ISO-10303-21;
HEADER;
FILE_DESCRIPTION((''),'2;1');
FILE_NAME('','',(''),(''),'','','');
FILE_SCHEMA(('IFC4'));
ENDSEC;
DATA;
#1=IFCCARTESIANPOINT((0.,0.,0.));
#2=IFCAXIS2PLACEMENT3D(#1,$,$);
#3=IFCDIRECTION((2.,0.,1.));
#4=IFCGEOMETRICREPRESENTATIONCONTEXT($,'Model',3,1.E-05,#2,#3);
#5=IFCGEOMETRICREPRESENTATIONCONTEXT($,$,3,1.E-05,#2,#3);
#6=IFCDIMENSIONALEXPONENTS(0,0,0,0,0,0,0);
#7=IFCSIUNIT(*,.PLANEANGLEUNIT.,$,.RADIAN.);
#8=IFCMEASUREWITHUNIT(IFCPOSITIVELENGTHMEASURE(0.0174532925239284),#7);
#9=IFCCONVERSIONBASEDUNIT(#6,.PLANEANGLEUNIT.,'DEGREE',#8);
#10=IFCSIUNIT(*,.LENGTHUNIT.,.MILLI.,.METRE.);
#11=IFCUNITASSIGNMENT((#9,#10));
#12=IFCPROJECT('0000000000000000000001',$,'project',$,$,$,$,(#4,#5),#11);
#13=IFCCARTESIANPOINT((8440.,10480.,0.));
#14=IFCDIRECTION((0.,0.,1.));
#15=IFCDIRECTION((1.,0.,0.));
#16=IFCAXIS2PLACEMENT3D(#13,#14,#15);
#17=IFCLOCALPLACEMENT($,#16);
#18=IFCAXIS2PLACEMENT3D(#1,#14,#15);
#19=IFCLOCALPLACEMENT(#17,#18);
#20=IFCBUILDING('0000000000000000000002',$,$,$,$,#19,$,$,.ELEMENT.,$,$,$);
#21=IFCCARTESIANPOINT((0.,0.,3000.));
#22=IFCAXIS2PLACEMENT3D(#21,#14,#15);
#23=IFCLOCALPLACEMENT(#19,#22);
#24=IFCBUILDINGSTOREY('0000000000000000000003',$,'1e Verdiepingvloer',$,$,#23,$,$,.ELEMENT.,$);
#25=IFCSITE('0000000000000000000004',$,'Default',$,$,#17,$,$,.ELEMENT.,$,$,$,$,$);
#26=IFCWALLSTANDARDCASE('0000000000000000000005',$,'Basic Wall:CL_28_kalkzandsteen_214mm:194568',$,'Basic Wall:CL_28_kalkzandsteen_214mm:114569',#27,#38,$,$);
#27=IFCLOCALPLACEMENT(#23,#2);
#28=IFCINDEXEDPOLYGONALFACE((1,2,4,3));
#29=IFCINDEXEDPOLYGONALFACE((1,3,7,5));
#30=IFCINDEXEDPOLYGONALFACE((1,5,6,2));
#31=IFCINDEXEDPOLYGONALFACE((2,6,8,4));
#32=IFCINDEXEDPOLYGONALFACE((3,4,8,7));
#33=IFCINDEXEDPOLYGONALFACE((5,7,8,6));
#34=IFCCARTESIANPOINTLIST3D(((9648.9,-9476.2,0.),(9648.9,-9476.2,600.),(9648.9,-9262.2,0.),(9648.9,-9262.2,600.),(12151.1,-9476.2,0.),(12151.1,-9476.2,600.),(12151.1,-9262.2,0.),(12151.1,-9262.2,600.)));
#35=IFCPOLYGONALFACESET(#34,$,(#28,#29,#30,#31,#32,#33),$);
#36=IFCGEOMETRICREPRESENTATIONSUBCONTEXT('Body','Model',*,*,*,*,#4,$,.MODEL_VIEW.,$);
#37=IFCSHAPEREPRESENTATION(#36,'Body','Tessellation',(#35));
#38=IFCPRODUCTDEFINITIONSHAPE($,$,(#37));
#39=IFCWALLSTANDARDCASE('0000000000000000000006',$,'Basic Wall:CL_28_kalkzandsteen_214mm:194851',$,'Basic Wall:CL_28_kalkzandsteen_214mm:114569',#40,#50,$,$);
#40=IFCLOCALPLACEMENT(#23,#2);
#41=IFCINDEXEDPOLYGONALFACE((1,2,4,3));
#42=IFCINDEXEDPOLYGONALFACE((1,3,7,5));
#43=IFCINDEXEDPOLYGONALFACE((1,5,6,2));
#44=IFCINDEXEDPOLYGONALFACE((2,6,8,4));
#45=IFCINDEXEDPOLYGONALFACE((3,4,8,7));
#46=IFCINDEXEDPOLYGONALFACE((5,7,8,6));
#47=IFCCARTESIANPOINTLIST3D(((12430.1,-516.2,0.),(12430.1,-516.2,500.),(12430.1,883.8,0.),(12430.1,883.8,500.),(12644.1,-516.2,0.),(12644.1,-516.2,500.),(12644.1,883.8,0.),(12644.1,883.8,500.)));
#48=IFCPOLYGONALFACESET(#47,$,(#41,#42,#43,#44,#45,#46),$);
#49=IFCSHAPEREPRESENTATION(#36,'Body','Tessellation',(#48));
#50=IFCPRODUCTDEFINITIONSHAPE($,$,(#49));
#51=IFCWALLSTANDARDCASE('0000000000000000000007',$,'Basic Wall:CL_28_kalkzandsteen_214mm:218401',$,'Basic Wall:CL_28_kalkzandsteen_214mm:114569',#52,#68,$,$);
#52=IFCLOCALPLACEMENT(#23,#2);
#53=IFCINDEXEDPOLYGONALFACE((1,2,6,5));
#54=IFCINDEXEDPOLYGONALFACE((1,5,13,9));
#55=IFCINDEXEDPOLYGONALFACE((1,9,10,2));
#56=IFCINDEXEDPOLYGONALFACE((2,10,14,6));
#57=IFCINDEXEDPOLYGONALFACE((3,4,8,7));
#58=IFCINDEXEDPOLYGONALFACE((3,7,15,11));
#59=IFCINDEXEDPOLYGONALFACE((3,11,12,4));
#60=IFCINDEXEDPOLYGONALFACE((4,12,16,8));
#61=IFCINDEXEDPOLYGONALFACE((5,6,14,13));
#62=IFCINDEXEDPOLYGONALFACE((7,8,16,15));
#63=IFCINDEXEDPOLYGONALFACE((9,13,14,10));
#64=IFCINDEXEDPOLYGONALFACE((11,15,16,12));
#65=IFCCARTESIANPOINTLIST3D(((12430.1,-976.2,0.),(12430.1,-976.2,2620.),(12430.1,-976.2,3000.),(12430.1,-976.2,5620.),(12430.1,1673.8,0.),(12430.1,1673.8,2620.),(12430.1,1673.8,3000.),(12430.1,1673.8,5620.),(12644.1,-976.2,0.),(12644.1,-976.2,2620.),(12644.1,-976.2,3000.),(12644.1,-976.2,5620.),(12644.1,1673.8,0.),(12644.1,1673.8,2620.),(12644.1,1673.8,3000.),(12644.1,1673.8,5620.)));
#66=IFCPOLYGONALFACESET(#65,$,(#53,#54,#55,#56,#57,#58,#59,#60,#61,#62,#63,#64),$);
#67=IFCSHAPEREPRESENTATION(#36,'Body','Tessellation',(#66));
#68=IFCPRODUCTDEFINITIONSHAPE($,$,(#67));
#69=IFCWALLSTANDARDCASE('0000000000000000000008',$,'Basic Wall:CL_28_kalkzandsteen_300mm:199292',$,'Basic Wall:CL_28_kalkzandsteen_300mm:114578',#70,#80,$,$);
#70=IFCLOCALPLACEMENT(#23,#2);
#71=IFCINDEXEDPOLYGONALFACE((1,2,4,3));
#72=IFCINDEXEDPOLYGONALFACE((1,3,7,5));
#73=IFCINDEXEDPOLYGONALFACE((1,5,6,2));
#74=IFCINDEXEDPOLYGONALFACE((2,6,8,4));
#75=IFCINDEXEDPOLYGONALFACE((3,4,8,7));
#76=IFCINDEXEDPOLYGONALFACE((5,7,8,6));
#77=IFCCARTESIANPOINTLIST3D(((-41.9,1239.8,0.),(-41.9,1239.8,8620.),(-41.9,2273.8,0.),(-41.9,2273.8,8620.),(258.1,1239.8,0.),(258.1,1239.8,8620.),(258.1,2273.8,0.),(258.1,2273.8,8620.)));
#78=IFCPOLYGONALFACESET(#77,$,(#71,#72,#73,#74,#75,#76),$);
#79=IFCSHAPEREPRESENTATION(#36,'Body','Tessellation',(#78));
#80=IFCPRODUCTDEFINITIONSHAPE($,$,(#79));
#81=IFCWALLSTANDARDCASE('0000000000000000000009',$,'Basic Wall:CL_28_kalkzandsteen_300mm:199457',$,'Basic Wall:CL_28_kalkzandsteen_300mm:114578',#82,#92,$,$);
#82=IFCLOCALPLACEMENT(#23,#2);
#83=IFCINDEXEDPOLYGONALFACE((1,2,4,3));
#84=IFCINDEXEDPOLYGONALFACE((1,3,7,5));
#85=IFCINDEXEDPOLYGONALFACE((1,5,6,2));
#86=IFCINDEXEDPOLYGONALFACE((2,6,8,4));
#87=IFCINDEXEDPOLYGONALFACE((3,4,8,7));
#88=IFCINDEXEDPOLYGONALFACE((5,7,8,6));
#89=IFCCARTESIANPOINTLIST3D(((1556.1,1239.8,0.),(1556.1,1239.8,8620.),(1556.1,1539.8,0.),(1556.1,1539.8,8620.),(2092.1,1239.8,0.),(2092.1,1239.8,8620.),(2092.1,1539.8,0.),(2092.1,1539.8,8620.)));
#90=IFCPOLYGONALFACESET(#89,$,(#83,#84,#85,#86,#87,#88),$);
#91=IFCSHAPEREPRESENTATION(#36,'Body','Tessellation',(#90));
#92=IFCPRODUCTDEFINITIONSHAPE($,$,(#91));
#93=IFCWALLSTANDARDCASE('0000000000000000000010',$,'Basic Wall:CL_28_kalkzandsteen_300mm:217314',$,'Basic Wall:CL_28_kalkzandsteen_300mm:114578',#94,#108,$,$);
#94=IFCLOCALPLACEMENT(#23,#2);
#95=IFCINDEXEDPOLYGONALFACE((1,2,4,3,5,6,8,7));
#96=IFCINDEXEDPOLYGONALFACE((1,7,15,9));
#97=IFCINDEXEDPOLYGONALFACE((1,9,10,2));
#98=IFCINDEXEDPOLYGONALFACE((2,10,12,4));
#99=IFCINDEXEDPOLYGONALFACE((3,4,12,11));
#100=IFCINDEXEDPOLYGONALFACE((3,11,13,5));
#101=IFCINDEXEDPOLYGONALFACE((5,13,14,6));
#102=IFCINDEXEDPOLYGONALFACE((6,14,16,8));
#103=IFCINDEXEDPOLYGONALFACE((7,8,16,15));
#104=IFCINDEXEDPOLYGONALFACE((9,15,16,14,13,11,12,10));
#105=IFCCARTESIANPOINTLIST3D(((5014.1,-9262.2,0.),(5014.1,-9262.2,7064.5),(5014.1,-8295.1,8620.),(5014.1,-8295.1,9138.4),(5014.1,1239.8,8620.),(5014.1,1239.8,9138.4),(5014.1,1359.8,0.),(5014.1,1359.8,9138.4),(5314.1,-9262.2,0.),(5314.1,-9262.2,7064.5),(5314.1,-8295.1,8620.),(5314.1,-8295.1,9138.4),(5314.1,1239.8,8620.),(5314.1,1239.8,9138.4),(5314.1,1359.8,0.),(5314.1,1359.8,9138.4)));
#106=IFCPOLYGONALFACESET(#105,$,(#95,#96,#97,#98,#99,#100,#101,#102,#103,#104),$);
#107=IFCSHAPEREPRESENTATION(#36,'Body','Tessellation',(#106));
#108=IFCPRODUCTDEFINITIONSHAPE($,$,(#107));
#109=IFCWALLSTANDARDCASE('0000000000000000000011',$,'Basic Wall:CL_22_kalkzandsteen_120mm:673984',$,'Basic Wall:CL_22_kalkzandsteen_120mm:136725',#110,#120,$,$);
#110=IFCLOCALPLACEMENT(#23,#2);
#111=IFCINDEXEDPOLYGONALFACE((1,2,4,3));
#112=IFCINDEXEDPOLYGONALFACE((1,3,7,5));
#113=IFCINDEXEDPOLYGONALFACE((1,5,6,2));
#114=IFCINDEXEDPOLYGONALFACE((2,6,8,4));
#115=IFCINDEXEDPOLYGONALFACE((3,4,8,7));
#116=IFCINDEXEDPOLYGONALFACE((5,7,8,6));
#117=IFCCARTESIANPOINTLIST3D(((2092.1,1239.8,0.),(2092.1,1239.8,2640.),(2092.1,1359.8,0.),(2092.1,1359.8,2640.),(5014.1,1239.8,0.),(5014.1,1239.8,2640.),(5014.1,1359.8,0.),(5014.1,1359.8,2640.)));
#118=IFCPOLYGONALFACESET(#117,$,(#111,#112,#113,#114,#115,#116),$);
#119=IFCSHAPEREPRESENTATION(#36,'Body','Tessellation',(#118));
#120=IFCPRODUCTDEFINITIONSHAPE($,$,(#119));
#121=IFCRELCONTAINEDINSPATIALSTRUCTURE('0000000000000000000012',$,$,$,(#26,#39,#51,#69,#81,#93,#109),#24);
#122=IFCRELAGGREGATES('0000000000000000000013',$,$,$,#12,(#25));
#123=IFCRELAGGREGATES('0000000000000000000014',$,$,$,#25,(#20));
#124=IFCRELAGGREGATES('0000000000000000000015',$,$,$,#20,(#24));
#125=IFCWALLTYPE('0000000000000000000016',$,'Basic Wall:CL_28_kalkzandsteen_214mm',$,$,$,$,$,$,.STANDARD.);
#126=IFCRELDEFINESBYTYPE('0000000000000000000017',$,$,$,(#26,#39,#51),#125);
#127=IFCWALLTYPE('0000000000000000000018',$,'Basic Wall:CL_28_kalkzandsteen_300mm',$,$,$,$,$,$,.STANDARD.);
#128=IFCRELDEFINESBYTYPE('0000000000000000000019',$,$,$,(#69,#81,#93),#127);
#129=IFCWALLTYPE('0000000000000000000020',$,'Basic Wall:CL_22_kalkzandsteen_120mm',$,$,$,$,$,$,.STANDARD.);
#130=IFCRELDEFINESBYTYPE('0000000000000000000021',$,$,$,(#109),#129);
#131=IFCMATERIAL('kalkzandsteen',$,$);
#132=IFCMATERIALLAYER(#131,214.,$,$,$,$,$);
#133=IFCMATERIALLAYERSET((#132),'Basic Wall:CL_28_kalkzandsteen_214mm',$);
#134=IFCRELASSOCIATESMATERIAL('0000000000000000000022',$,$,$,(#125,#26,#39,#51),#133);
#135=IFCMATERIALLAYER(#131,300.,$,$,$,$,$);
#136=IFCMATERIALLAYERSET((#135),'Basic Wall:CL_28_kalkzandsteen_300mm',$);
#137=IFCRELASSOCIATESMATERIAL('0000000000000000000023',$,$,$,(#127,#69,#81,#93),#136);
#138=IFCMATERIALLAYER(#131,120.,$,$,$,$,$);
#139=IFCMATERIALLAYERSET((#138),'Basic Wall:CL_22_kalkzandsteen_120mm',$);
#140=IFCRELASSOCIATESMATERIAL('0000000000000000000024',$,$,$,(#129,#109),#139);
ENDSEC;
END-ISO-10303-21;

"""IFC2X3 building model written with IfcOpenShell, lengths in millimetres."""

from ifc_helpers import new_model, entity, si_unit, converted_unit, direction, frame, frame_2d, origin, origin_with_axes, place, context, subcontext, project, spatial, polyline, rectangle, extrude, clip, bounded_halfspace, material, layer, layer_set, layer_usage, type_object, element, save


model = new_model("IFC2X3")

# Units and contexts
model_context = context("Model", 3, precision=1e-05, world=origin(), true_north=direction((2.0, 0.0, 1.0)))
context_of_model = context(None, 3, precision=1e-05, world=origin(), true_north=direction((2.0, 0.0, 1.0)))
body_context = subcontext(model_context, "Body", "Model", "MODEL_VIEW")
ifc_project = project(units=[converted_unit("PLANEANGLEUNIT", "DEGREE", entity("IfcPositiveLengthMeasure", 0.0174532925239284), si_unit("PLANEANGLEUNIT", "RADIAN"), dimensions=[0, 0, 0, 0, 0, 0, 0]), si_unit("LENGTHUNIT", "METRE", prefix="MILLI")], contexts=[model_context, context_of_model])

# Site, building, storey
site_placement = place(None, frame((8440.0, 10480.0, 0.0), z_axis=(0.0, 0.0, 1.0), x_axis=(1.0, 0.0, 0.0)))
site = spatial("IfcSite", under=ifc_project, at=site_placement, Name="Default", CompositionType="ELEMENT")
building_placement = place(site_placement, origin_with_axes())
building = spatial("IfcBuilding", under=site, at=building_placement, CompositionType="ELEMENT")
storey_placement = place(building_placement, frame((0.0, 0.0, 3000.0), z_axis=(0.0, 0.0, 1.0), x_axis=(1.0, 0.0, 0.0)))
storey = spatial("IfcBuildingStorey", under=building, at=storey_placement, Name="1e Verdiepingvloer", CompositionType="ELEMENT")

# Walls
ifc_material_1 = material(Name="kalkzandsteen")
ifc_layer_1 = layer(ifc_material_1, 214.0)
ifc_layer_set_1 = layer_set([ifc_layer_1], Name="Basic Wall:CL_28_kalkzandsteen_214mm")
wall_type_1 = type_object("IfcWallType", Name="Basic Wall:CL_28_kalkzandsteen_214mm", PredefinedType="STANDARD", material=ifc_layer_set_1)
ifc_layer_usage_1 = layer_usage(ifc_layer_set_1, "AXIS2", "NEGATIVE", 107.0)
wall_1_placement = place(storey_placement, frame((9648.9, -9369.2, 0.0), z_axis=(0.0, 0.0, 1.0), x_axis=(1.0, 0.0, 0.0)))
element("IfcWallStandardCase", 1, at=wall_1_placement, inside=storey, type_object=wall_type_1, material=ifc_layer_usage_1, Name="Basic Wall:CL_28_kalkzandsteen_214mm:194568", ObjectType="Basic Wall:CL_28_kalkzandsteen_214mm:114569", context=body_context, shape_type="SweptSolid", body=[
    extrude(rectangle(XDim=2502.2, YDim=214.0, at=frame_2d((1251.1, 0.0), x_axis=(-1.0, 0.0))), origin(), (0.0, 0.0, 1.0), 600.0),
])
ifc_layer_usage_2 = layer_usage(ifc_layer_set_1, "AXIS2", "NEGATIVE", 107.0)
wall_2_placement = place(storey_placement, frame((12537.1, -516.2, 0.0), z_axis=(0.0, 0.0, 1.0), x_axis=(0.0, 1.0, 0.0)))
element("IfcWallStandardCase", 2, at=wall_2_placement, inside=storey, type_object=wall_type_1, material=ifc_layer_usage_2, Name="Basic Wall:CL_28_kalkzandsteen_214mm:194851", ObjectType="Basic Wall:CL_28_kalkzandsteen_214mm:114569", context=body_context, shape_type="SweptSolid", body=[
    extrude(rectangle(XDim=1400.0, YDim=214.0, at=frame_2d((700.0, 0.0), x_axis=(-1.0, 0.0))), origin(), (0.0, 0.0, 1.0), 500.0),
])

# Wall, opening
ifc_layer_usage_3 = layer_usage(ifc_layer_set_1, "AXIS2", "NEGATIVE", 107.0)
wall_3_placement = place(storey_placement, frame((12537.1, -976.2, 0.0), z_axis=(0.0, 0.0, 1.0), x_axis=(0.0, 1.0, 0.0)))
wall_3 = element("IfcWallStandardCase", 3, at=wall_3_placement, inside=storey, type_object=wall_type_1, material=ifc_layer_usage_3, Name="Basic Wall:CL_28_kalkzandsteen_214mm:218401", ObjectType="Basic Wall:CL_28_kalkzandsteen_214mm:114569", context=body_context, shape_type="Clipping", body=[
    clip(extrude(rectangle(XDim=2650.0, YDim=214.0, at=frame_2d((1325.0, 0.0), x_axis=(-1.0, 0.0))), origin(), (0.0, 0.0, 1.0), 5620.0), bounded_halfspace(frame((0.0, -107.0, 5620.0), z_axis=(0.0, 0.0, -1.0), x_axis=(0.0, -1.0, 0.0)), True, frame((0.0, -107.0, 5620.0)), polyline([(0.0, 0.0), (2650.0, 0.0), (2650.0, 214.0), (0.0, 214.0), (0.0, 0.0)]))),
])
opening_placement = place(wall_3_placement, origin_with_axes())
element("IfcOpeningElement", 4, at=opening_placement, cuts=wall_3, ObjectType="Opening", context=body_context, shape_type="SweptSolid", body=[
    extrude(rectangle(XDim=2650.0, YDim=214.0, at=frame_2d((0.0, 0.0), x_axis=(1.0, 0.0))), frame((1325.0, 0.0, 2620.0)), (0.0, 0.0, 1.0), 380.0),
])

# Walls
ifc_layer_2 = layer(ifc_material_1, 300.0)
ifc_layer_set_2 = layer_set([ifc_layer_2], Name="Basic Wall:CL_28_kalkzandsteen_300mm")
ifc_layer_usage_4 = layer_usage(ifc_layer_set_2, "AXIS2", "NEGATIVE", 150.0)
wall_type_2 = type_object("IfcWallType", Name="Basic Wall:CL_28_kalkzandsteen_300mm", PredefinedType="STANDARD", material=ifc_layer_set_2)
wall_4_placement = place(storey_placement, frame((108.1, 1239.8, 0.0), z_axis=(0.0, 0.0, 1.0), x_axis=(0.0, 1.0, 0.0)))
element("IfcWallStandardCase", 5, at=wall_4_placement, inside=storey, type_object=wall_type_2, material=ifc_layer_usage_4, Name="Basic Wall:CL_28_kalkzandsteen_300mm:199292", ObjectType="Basic Wall:CL_28_kalkzandsteen_300mm:114578", context=body_context, shape_type="Clipping", body=[
    clip(extrude(rectangle(XDim=1034.0, YDim=300.0, at=frame_2d((517.0, 0.0), x_axis=(-1.0, 0.0))), origin(), (0.0, 0.0, 1.0), 8620.0), bounded_halfspace(frame((0.0, -150.0, 8620.0), z_axis=(0.0, 0.0, -1.0), x_axis=(-1.0, 0.0, 0.0)), True, frame((0.0, -150.0, 8620.0)), polyline([(0.0, 0.0), (1034.0, 0.0), (1034.0, 300.0), (734.0, 300.0), (0.0, 300.0), (0.0, 0.0)]))),
])
ifc_layer_usage_5 = layer_usage(ifc_layer_set_2, "AXIS2", "NEGATIVE", 150.0)
wall_5_placement = place(storey_placement, frame((1556.1, 1389.8, 0.0), z_axis=(0.0, 0.0, 1.0), x_axis=(1.0, 0.0, 0.0)))
element("IfcWallStandardCase", 6, at=wall_5_placement, inside=storey, type_object=wall_type_2, material=ifc_layer_usage_5, Name="Basic Wall:CL_28_kalkzandsteen_300mm:199457", ObjectType="Basic Wall:CL_28_kalkzandsteen_300mm:114578", context=body_context, shape_type="Clipping", body=[
    clip(extrude(rectangle(XDim=536.0, YDim=300.0, at=frame_2d((268.0, 0.0), x_axis=(-1.0, 0.0))), origin(), (0.0, 0.0, 1.0), 8620.0), bounded_halfspace(frame((0.0, -150.0, 8620.0), z_axis=(0.0, 0.0, -1.0), x_axis=(0.0, -1.0, 0.0)), True, frame((0.0, -150.0, 8620.0)), polyline([(0.0, 0.0), (536.0, 0.0), (536.0, 120.0), (536.0, 300.0), (0.0, 300.0), (0.0, 0.0)]))),
])
ifc_layer_usage_6 = layer_usage(ifc_layer_set_2, "AXIS2", "NEGATIVE", 150.0)
wall_6_placement = place(storey_placement, frame((5164.1, -9262.2, 0.0), z_axis=(0.0, 0.0, 1.0), x_axis=(0.0, 1.0, 0.0)))
element("IfcWallStandardCase", 7, at=wall_6_placement, inside=storey, type_object=wall_type_2, material=ifc_layer_usage_6, Name="Basic Wall:CL_28_kalkzandsteen_300mm:217314", ObjectType="Basic Wall:CL_28_kalkzandsteen_300mm:114578", context=body_context, shape_type="Clipping", body=[
    clip(clip(extrude(rectangle(XDim=10622.0, YDim=300.0, at=frame_2d((5311.0, 0.0), x_axis=(-1.0, 0.0))), origin(), (0.0, 0.0, 1.0), 9138.4), bounded_halfspace(frame((0.0, -150.0, 7064.5), z_axis=(-0.906308, 0.0, 0.422618), x_axis=(0.0, -1.0, 0.0)), False, frame((0.0, -150.0, 7064.5)), polyline([(0.0, 0.0), (967.1, 0.0), (967.1, 300.0), (0.0, 300.0), (0.0, 0.0)]))), bounded_halfspace(frame((967.1, -150.0, 8620.0), z_axis=(0.0, 0.0, 1.0), x_axis=(0.0, 1.0, 0.0)), False, frame((967.1, -150.0, 8620.0)), polyline([(0.0, 0.0), (9534.9, 0.0), (9534.9, 214.0), (9534.9, 300.0), (0.0, 300.0), (0.0, 0.0)]))),
])
ifc_layer_3 = layer(ifc_material_1, 120.0)
ifc_layer_set_3 = layer_set([ifc_layer_3], Name="Basic Wall:CL_22_kalkzandsteen_120mm")
ifc_layer_usage_7 = layer_usage(ifc_layer_set_3, "AXIS2", "NEGATIVE", 60.0)
wall_type_3 = type_object("IfcWallType", Name="Basic Wall:CL_22_kalkzandsteen_120mm", PredefinedType="STANDARD", material=ifc_layer_set_3)
wall_7_placement = place(storey_placement, frame((5014.1, 1299.8, 0.0), z_axis=(0.0, 0.0, 1.0), x_axis=(-1.0, 0.0, 0.0)))
element("IfcWallStandardCase", 8, at=wall_7_placement, inside=storey, type_object=wall_type_3, material=ifc_layer_usage_7, Name="Basic Wall:CL_22_kalkzandsteen_120mm:673984", ObjectType="Basic Wall:CL_22_kalkzandsteen_120mm:136725", context=body_context, shape_type="SweptSolid", body=[
    extrude(rectangle(XDim=2922.0, YDim=120.0, at=frame_2d((1461.0, 0.0), x_axis=(-1.0, 0.0))), origin(), (0.0, 0.0, 1.0), 2640.0),
])

save(model, "model.ifc")
